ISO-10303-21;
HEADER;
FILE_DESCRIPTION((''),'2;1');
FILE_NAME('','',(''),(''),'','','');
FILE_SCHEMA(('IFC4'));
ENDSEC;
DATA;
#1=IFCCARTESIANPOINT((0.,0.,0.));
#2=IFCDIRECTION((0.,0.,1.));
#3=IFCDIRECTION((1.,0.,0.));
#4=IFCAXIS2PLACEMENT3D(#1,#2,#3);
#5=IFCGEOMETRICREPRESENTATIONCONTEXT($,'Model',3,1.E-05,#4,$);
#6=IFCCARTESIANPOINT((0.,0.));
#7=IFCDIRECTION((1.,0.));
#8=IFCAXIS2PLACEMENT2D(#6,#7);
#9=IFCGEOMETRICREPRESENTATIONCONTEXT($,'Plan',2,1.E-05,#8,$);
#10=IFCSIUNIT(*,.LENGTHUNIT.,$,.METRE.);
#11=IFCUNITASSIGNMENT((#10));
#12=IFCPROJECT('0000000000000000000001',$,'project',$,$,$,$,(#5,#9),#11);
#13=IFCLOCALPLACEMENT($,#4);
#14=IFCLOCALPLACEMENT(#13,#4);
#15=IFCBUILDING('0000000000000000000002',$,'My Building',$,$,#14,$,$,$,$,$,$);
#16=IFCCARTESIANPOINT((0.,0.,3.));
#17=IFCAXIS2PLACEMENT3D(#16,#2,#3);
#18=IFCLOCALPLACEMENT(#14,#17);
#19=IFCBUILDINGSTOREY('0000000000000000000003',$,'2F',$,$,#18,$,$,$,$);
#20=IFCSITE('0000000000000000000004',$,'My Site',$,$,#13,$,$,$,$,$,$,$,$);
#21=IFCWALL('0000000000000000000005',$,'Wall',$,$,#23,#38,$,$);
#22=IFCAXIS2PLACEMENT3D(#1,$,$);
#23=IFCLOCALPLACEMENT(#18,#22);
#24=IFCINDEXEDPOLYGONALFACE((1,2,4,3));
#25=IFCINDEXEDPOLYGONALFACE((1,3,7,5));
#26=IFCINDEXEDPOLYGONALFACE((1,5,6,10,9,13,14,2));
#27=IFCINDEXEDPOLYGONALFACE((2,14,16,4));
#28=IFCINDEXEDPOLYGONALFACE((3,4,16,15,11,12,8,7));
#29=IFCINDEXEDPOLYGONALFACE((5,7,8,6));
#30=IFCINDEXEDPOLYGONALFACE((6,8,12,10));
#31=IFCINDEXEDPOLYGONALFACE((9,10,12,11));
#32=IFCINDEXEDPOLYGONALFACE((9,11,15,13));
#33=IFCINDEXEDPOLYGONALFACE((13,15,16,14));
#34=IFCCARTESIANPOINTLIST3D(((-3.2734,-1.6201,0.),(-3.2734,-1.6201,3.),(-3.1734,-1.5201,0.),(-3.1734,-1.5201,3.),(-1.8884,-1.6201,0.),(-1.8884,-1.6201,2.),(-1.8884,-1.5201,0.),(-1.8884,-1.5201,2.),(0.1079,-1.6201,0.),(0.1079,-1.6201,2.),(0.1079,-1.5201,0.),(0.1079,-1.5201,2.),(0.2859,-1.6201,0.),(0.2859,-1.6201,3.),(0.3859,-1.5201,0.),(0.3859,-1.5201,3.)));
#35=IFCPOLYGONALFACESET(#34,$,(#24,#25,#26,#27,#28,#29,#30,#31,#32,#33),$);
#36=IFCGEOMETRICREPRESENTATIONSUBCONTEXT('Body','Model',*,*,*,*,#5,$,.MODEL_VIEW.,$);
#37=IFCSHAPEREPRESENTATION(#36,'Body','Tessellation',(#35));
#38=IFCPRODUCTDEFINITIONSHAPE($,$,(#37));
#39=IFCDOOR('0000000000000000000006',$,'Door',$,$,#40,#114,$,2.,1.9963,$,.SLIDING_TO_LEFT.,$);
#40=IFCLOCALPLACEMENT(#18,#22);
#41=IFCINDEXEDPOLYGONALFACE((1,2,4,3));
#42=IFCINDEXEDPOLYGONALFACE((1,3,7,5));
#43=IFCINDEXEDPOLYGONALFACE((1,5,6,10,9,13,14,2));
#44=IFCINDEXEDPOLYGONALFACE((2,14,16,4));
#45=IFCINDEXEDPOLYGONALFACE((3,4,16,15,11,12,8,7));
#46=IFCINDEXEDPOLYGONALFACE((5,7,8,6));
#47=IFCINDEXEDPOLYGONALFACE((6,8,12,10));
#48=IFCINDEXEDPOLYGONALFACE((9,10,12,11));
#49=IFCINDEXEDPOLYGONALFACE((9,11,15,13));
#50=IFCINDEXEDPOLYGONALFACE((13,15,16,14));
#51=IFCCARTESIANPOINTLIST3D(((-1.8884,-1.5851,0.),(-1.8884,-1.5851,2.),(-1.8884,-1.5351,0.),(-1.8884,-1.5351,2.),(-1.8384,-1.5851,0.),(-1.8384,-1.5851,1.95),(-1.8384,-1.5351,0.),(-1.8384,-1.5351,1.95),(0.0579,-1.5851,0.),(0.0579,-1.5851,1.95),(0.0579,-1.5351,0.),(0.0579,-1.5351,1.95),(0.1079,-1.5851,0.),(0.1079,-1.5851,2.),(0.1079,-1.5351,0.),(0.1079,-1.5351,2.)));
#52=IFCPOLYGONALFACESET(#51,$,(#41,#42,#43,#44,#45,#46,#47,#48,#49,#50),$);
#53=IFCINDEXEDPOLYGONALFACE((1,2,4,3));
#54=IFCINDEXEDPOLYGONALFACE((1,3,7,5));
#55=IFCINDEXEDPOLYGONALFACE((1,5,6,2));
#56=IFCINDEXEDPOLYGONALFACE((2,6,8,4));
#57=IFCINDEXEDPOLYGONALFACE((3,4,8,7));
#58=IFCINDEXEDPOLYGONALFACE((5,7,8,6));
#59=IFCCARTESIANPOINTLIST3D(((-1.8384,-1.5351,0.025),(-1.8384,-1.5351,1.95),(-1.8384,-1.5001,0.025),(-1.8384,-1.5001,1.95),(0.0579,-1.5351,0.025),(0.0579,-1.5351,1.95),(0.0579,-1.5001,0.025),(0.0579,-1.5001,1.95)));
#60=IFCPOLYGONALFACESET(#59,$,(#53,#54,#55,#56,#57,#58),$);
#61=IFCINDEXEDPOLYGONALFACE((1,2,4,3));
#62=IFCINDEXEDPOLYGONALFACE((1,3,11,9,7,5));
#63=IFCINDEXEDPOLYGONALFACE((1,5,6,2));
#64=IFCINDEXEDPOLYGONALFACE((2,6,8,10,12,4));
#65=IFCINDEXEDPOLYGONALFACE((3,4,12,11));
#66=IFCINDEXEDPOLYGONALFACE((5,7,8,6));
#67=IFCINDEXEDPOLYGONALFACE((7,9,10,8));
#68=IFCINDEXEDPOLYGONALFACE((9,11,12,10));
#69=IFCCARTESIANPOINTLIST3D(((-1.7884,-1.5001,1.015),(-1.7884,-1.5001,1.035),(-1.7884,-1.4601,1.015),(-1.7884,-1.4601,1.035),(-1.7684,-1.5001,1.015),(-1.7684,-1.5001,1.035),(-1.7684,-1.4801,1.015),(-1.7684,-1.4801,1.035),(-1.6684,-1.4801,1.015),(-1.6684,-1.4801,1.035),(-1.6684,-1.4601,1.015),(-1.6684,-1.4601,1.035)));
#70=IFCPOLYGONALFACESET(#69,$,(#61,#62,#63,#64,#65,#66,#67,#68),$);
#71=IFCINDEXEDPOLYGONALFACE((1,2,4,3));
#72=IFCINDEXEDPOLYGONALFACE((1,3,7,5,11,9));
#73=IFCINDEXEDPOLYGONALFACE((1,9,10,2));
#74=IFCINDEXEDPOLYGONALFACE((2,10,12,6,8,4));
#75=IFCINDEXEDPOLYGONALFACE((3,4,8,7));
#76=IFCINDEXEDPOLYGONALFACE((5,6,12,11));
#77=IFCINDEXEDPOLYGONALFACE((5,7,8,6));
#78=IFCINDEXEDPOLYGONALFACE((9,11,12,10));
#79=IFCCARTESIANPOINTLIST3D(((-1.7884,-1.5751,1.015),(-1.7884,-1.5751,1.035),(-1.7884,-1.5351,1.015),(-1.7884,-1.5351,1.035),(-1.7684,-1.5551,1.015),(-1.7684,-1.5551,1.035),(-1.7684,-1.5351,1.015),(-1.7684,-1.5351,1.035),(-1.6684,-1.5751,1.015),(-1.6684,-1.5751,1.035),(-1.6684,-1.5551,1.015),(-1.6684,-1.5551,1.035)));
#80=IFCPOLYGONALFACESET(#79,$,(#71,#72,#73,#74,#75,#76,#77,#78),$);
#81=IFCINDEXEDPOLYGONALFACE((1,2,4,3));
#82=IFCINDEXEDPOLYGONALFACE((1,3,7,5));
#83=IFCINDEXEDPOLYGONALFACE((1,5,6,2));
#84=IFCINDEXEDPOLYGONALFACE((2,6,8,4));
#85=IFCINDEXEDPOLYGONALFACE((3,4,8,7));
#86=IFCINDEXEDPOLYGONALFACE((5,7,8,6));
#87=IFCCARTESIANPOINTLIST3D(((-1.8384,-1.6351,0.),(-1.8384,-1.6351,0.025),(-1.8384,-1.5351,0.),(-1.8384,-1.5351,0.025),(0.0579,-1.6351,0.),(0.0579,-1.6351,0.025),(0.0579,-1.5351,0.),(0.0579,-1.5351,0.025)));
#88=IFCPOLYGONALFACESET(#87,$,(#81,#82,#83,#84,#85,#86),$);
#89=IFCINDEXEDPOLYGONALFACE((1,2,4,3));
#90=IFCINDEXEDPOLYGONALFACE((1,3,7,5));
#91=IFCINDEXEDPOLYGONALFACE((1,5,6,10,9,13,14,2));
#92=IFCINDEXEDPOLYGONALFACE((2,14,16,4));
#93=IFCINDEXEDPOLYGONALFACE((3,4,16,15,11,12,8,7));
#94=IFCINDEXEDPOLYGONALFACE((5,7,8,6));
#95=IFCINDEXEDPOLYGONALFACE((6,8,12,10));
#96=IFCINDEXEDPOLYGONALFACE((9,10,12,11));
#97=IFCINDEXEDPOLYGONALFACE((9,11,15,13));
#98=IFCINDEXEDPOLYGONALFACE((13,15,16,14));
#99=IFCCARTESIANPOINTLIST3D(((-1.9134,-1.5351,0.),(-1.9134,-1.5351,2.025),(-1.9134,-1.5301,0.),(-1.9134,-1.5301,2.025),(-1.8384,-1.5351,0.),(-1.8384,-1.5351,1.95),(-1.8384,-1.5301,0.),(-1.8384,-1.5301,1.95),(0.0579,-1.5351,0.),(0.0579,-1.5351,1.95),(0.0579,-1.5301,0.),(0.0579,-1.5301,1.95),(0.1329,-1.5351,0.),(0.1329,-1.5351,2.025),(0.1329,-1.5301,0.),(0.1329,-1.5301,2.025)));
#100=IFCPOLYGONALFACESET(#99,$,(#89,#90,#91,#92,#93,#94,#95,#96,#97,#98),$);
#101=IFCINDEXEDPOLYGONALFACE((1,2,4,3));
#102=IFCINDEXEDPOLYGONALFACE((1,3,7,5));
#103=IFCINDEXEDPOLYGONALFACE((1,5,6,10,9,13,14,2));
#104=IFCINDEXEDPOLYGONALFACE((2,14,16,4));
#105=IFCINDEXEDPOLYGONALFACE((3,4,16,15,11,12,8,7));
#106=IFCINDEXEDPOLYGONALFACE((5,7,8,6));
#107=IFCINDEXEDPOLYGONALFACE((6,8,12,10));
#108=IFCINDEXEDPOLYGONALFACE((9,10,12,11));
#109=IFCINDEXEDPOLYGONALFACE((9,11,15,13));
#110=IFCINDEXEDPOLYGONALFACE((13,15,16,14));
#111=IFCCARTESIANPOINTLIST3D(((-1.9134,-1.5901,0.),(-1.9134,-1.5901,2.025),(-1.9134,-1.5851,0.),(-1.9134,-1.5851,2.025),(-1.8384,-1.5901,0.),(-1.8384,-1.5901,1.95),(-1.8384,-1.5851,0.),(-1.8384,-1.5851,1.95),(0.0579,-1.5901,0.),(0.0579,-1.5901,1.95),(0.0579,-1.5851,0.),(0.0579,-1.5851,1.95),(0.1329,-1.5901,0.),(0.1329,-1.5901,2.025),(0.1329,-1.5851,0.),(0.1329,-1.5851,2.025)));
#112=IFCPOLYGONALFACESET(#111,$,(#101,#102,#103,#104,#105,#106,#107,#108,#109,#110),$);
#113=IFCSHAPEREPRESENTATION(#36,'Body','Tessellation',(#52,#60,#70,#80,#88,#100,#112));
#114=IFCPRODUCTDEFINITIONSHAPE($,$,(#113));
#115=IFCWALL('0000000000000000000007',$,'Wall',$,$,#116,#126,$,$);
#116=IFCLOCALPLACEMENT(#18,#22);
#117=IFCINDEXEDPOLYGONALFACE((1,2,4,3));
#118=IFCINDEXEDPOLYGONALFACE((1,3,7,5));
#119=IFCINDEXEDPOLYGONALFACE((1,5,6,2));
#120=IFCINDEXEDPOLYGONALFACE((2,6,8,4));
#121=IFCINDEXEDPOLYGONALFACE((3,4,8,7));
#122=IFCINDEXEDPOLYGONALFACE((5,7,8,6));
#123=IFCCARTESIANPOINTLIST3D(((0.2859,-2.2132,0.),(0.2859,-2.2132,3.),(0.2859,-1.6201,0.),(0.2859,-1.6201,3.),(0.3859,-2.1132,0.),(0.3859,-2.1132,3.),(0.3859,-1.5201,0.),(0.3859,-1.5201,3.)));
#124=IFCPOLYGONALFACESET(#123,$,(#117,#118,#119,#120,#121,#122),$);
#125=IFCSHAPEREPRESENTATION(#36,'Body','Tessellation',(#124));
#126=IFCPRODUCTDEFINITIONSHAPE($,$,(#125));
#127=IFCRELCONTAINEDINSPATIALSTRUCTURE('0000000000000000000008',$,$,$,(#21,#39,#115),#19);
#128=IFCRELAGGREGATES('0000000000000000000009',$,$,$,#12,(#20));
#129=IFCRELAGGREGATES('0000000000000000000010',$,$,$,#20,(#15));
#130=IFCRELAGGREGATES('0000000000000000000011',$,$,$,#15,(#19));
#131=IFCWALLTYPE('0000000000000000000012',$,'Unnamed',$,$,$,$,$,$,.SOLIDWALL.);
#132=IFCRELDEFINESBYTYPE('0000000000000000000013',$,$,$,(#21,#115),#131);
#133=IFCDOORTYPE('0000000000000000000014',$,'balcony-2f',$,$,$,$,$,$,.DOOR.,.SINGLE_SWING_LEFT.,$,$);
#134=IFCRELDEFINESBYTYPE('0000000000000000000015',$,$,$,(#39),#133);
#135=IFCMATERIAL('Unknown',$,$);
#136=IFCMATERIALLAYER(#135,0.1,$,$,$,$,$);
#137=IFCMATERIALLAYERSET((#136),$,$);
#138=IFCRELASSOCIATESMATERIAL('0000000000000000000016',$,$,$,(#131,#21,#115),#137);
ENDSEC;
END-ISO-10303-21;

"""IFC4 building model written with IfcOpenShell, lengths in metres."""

from ifc_helpers import new_model, entity, si_unit, frame, origin_with_axes, origin_2d_with_axis, place, context, subcontext, project, spatial, line, indexed_curve, outline, extrude, shape, source, transform, mapped, material, layer, layer_set, layer_usage, type_object, type_shapes, element, fill, save


model = new_model("IFC4")

# Units and contexts
model_context = context("Model", 3, precision=1e-05, world=origin_with_axes())
plan_context = context("Plan", 2, precision=1e-05, world=origin_2d_with_axis())
body_context_1 = subcontext(model_context, "Body", "Model", "MODEL_VIEW")
body_context_2 = subcontext(plan_context, "Body", "Plan", "PLAN_VIEW")
ifc_project = project(units=[si_unit("LENGTHUNIT", "METRE")], contexts=[model_context, plan_context])

# Site, building, storey
site_placement = place(None, origin_with_axes())
site = spatial("IfcSite", under=ifc_project, at=site_placement, Name="My Site")
building_placement = place(site_placement, origin_with_axes())
building = spatial("IfcBuilding", under=site, at=building_placement, Name="My Building")
storey_placement = place(building_placement, frame((0.0, 0.0, 3.0), z_axis=(0.0, 0.0, 1.0), x_axis=(1.0, 0.0, 0.0)))
storey = spatial("IfcBuildingStorey", under=building, at=storey_placement, Name="2F")

# Shared definitions
ifc_material = material(Name="Unknown")

# Shared definitions
ifc_layer_1 = layer(ifc_material, 0.1)
ifc_layer_set_1 = layer_set([ifc_layer_1])
wall_type = type_object("IfcWallType", Name="Unnamed", PredefinedType="SOLIDWALL", material=ifc_layer_set_1)

# Wall, opening, door
ifc_layer_usage_1 = layer_usage(ifc_layer_set_1, "AXIS2", "POSITIVE", 0.0)
wall_1_placement = place(storey_placement, frame((-3.2734, -1.6201, 0.0), z_axis=(0.0, 0.0, 1.0), x_axis=(1.0, 0.0, 0.0)))
wall_1 = element("IfcWall", 1, at=wall_1_placement, inside=storey, type_object=wall_type, material=ifc_layer_usage_1, Name="Wall", context=body_context_1, shape_type="SweptSolid", body=[
    extrude(outline(indexed_curve([(0.0, 0.0), (0.1, 0.1), (3.6593, 0.1), (3.5593, 0.0)], segments=[line(1, 2, 3, 4, 1)])), origin_with_axes(), (0.0, 0.0, 1.0), 3.0),
])
shared_shape_1 = source(origin_with_axes(), body_context_1, "Body", "SweptSolid", [
    extrude(outline(indexed_curve([(0.0, 0.0), (1.9963, 0.0), (1.9963, 2.0), (0.0, 2.0)], segments=[line(1, 2, 3, 4, 1)])), frame((0.0, -0.6, 0.0), z_axis=(0.0, -1.0, 0.0), x_axis=(1.0, 0.0, 0.0)), (0.0, 0.0, -1.0), 1.2),
])
opening_1_placement = place(wall_1_placement, frame((3.3813, 0.085, 0.0), z_axis=(0.0, 0.0, 1.0), x_axis=(-1.0, 0.000001, 0.0)))
opening_1 = element("IfcOpeningElement", 2, at=opening_1_placement, cuts=wall_1, PredefinedType="OPENING", context=body_context_1, shape_type="MappedRepresentation", body=[
    mapped(shared_shape_1, transform((0.0, 0.0, 0.0), x_axis=(1.0, 0.0, 0.0), y_axis=(0.0, 1.0, 0.0), z_axis=(0.0, 0.0, 1.0), scale=1.0)),
])
door_type_1 = type_object("IfcDoorType", Name="balcony-2f", OperationType="SINGLE_SWING_LEFT", PredefinedType="DOOR")
shared_shape_2 = source(origin_with_axes(), body_context_1, "Body", "SweptSolid", [
    extrude(outline(indexed_curve([(0.0, 0.0), (0.0, 2.0), (1.9963, 2.0), (1.9963, 0.0), (1.9463, 0.0), (1.9463, 1.95), (0.05, 1.95), (0.05, 0.0)], segments=[line(1, 2, 3, 4, 5, 6, 7, 8, 1)])), frame((0.0, 0.0, 0.0), z_axis=(0.0, -1.0, 0.0), x_axis=(1.0, 0.0, 0.0)), (0.0, 0.0, -1.0), 0.05),
    extrude(outline(indexed_curve([(0.0, 0.0), (1.8963, 0.0), (1.8963, 0.035), (0.0, 0.035)], segments=[line(1, 2, 3, 4, 1)])), frame((0.05, -0.035, 0.025), z_axis=(0.0, 0.0, 1.0), x_axis=(1.0, 0.0, 0.0)), (0.0, 0.0, 1.0), 1.925),
    extrude(outline(indexed_curve([(0.0, 0.0), (0.0, -0.04), (-0.12, -0.04), (-0.12, -0.02), (-0.02, -0.02), (-0.02, 0.0)], segments=[line(1, 2, 3, 4, 5, 6, 1)])), frame((1.8963, -0.035, 1.015), z_axis=(0.0, 0.0, 1.0), x_axis=(1.0, 0.0, 0.0)), (0.0, 0.0, 1.0), 0.02),
    extrude(outline(indexed_curve([(0.0, 0.0), (0.0, 0.04), (-0.12, 0.04), (-0.12, 0.02), (-0.02, 0.02), (-0.02, 0.0)], segments=[line(1, 2, 3, 4, 5, 6, 1)])), frame((1.8963, 0.0, 1.015), z_axis=(0.0, 0.0, 1.0), x_axis=(1.0, 0.0, 0.0)), (0.0, 0.0, 1.0), 0.02),
    extrude(outline(indexed_curve([(0.0, 0.0), (1.8963, 0.0), (1.8963, 0.1), (0.0, 0.1)], segments=[line(1, 2, 3, 4, 1)])), frame((0.05, 0.0, 0.0), z_axis=(0.0, 0.0, 1.0), x_axis=(1.0, 0.0, 0.0)), (0.0, 0.0, 1.0), 0.025),
    extrude(outline(indexed_curve([(0.0, 0.0), (0.0, 2.025), (2.0463, 2.025), (2.0463, 0.0), (1.9713, 0.0), (1.9713, 1.95), (0.075, 1.95), (0.075, 0.0)], segments=[line(1, 2, 3, 4, 5, 6, 7, 8, 1)])), frame((-0.025, -0.005, 0.0), z_axis=(0.0, -1.0, 0.0), x_axis=(1.0, 0.0, 0.0)), (0.0, 0.0, -1.0), 0.005),
    extrude(outline(indexed_curve([(0.0, 0.0), (0.0, 2.025), (2.0463, 2.025), (2.0463, 0.0), (1.9713, 0.0), (1.9713, 1.95), (0.075, 1.95), (0.075, 0.0)], segments=[line(1, 2, 3, 4, 5, 6, 7, 8, 1)])), frame((-0.025, 0.05, 0.0), z_axis=(0.0, -1.0, 0.0), x_axis=(1.0, 0.0, 0.0)), (0.0, 0.0, -1.0), 0.005),
])
shared_shape_3 = source(origin_with_axes(), body_context_2, "Body", "Curve2D", [
    entity("IfcIndexedPolyCurve", entity("IfcCartesianPointList2D", [[0.0, 0.0], [0.05, 0.0], [0.05, 0.05], [0.0, 0.05]]), [entity("IfcLineIndex", [1, 2, 3, 4, 1])]),
    entity("IfcIndexedPolyCurve", entity("IfcCartesianPointList2D", [[1.9963, 0.0], [1.9463, 0.0], [1.9463, 0.05], [1.9963, 0.05]]), [entity("IfcLineIndex", [1, 2, 3, 4, 1])]),
    entity("IfcIndexedPolyCurve", entity("IfcCartesianPointList2D", [[-0.8982, -0.035], [0.9982, -0.035], [0.9982, 0.0], [-0.8982, 0.0]]), [entity("IfcLineIndex", [1, 2, 3, 4, 1])]),
])
type_shapes(door_type_1, [shared_shape_2, shared_shape_3])
door_1_placement = place(opening_1_placement, origin_with_axes())
door_1 = element("IfcDoor", 3, at=door_1_placement, inside=storey, type_object=door_type_1, Name="Door", OperationType="SLIDING_TO_LEFT", OverallHeight=2.0, OverallWidth=1.9963, shapes=[
    shape(body_context_1, "Body", "MappedRepresentation", [mapped(shared_shape_2, transform((0.0, 0.0, 0.0), x_axis=(1.0, 0.0, 0.0), y_axis=(0.0, 1.0, 0.0), z_axis=(0.0, 0.0, 1.0), scale=1.0))]),
    shape(body_context_2, "Body", "MappedRepresentation", [mapped(shared_shape_3, transform((0.0, 0.0, 0.0), x_axis=(1.0, 0.0, 0.0), y_axis=(0.0, 1.0, 0.0), z_axis=(0.0, 0.0, 1.0), scale=1.0))]),
])
fill(opening_1, door_1)

# Wall
ifc_layer_usage_2 = layer_usage(ifc_layer_set_1, "AXIS2", "POSITIVE", 0.0)
wall_2_placement = place(storey_placement, frame((0.3859, -2.2132, 0.0), z_axis=(0.0, 0.0, 1.0), x_axis=(0.0, 1.0, 0.0)))
element("IfcWall", 4, at=wall_2_placement, inside=storey, type_object=wall_type, material=ifc_layer_usage_2, Name="Wall", context=body_context_1, shape_type="SweptSolid", body=[
    extrude(outline(indexed_curve([(0.1, 0.0), (0.0, 0.1), (0.5931, 0.1), (0.6931, 0.0)], segments=[line(1, 2, 3, 4, 1)])), origin_with_axes(), (0.0, 0.0, 1.0), 3.0),
])

save(model, "model.ifc")
